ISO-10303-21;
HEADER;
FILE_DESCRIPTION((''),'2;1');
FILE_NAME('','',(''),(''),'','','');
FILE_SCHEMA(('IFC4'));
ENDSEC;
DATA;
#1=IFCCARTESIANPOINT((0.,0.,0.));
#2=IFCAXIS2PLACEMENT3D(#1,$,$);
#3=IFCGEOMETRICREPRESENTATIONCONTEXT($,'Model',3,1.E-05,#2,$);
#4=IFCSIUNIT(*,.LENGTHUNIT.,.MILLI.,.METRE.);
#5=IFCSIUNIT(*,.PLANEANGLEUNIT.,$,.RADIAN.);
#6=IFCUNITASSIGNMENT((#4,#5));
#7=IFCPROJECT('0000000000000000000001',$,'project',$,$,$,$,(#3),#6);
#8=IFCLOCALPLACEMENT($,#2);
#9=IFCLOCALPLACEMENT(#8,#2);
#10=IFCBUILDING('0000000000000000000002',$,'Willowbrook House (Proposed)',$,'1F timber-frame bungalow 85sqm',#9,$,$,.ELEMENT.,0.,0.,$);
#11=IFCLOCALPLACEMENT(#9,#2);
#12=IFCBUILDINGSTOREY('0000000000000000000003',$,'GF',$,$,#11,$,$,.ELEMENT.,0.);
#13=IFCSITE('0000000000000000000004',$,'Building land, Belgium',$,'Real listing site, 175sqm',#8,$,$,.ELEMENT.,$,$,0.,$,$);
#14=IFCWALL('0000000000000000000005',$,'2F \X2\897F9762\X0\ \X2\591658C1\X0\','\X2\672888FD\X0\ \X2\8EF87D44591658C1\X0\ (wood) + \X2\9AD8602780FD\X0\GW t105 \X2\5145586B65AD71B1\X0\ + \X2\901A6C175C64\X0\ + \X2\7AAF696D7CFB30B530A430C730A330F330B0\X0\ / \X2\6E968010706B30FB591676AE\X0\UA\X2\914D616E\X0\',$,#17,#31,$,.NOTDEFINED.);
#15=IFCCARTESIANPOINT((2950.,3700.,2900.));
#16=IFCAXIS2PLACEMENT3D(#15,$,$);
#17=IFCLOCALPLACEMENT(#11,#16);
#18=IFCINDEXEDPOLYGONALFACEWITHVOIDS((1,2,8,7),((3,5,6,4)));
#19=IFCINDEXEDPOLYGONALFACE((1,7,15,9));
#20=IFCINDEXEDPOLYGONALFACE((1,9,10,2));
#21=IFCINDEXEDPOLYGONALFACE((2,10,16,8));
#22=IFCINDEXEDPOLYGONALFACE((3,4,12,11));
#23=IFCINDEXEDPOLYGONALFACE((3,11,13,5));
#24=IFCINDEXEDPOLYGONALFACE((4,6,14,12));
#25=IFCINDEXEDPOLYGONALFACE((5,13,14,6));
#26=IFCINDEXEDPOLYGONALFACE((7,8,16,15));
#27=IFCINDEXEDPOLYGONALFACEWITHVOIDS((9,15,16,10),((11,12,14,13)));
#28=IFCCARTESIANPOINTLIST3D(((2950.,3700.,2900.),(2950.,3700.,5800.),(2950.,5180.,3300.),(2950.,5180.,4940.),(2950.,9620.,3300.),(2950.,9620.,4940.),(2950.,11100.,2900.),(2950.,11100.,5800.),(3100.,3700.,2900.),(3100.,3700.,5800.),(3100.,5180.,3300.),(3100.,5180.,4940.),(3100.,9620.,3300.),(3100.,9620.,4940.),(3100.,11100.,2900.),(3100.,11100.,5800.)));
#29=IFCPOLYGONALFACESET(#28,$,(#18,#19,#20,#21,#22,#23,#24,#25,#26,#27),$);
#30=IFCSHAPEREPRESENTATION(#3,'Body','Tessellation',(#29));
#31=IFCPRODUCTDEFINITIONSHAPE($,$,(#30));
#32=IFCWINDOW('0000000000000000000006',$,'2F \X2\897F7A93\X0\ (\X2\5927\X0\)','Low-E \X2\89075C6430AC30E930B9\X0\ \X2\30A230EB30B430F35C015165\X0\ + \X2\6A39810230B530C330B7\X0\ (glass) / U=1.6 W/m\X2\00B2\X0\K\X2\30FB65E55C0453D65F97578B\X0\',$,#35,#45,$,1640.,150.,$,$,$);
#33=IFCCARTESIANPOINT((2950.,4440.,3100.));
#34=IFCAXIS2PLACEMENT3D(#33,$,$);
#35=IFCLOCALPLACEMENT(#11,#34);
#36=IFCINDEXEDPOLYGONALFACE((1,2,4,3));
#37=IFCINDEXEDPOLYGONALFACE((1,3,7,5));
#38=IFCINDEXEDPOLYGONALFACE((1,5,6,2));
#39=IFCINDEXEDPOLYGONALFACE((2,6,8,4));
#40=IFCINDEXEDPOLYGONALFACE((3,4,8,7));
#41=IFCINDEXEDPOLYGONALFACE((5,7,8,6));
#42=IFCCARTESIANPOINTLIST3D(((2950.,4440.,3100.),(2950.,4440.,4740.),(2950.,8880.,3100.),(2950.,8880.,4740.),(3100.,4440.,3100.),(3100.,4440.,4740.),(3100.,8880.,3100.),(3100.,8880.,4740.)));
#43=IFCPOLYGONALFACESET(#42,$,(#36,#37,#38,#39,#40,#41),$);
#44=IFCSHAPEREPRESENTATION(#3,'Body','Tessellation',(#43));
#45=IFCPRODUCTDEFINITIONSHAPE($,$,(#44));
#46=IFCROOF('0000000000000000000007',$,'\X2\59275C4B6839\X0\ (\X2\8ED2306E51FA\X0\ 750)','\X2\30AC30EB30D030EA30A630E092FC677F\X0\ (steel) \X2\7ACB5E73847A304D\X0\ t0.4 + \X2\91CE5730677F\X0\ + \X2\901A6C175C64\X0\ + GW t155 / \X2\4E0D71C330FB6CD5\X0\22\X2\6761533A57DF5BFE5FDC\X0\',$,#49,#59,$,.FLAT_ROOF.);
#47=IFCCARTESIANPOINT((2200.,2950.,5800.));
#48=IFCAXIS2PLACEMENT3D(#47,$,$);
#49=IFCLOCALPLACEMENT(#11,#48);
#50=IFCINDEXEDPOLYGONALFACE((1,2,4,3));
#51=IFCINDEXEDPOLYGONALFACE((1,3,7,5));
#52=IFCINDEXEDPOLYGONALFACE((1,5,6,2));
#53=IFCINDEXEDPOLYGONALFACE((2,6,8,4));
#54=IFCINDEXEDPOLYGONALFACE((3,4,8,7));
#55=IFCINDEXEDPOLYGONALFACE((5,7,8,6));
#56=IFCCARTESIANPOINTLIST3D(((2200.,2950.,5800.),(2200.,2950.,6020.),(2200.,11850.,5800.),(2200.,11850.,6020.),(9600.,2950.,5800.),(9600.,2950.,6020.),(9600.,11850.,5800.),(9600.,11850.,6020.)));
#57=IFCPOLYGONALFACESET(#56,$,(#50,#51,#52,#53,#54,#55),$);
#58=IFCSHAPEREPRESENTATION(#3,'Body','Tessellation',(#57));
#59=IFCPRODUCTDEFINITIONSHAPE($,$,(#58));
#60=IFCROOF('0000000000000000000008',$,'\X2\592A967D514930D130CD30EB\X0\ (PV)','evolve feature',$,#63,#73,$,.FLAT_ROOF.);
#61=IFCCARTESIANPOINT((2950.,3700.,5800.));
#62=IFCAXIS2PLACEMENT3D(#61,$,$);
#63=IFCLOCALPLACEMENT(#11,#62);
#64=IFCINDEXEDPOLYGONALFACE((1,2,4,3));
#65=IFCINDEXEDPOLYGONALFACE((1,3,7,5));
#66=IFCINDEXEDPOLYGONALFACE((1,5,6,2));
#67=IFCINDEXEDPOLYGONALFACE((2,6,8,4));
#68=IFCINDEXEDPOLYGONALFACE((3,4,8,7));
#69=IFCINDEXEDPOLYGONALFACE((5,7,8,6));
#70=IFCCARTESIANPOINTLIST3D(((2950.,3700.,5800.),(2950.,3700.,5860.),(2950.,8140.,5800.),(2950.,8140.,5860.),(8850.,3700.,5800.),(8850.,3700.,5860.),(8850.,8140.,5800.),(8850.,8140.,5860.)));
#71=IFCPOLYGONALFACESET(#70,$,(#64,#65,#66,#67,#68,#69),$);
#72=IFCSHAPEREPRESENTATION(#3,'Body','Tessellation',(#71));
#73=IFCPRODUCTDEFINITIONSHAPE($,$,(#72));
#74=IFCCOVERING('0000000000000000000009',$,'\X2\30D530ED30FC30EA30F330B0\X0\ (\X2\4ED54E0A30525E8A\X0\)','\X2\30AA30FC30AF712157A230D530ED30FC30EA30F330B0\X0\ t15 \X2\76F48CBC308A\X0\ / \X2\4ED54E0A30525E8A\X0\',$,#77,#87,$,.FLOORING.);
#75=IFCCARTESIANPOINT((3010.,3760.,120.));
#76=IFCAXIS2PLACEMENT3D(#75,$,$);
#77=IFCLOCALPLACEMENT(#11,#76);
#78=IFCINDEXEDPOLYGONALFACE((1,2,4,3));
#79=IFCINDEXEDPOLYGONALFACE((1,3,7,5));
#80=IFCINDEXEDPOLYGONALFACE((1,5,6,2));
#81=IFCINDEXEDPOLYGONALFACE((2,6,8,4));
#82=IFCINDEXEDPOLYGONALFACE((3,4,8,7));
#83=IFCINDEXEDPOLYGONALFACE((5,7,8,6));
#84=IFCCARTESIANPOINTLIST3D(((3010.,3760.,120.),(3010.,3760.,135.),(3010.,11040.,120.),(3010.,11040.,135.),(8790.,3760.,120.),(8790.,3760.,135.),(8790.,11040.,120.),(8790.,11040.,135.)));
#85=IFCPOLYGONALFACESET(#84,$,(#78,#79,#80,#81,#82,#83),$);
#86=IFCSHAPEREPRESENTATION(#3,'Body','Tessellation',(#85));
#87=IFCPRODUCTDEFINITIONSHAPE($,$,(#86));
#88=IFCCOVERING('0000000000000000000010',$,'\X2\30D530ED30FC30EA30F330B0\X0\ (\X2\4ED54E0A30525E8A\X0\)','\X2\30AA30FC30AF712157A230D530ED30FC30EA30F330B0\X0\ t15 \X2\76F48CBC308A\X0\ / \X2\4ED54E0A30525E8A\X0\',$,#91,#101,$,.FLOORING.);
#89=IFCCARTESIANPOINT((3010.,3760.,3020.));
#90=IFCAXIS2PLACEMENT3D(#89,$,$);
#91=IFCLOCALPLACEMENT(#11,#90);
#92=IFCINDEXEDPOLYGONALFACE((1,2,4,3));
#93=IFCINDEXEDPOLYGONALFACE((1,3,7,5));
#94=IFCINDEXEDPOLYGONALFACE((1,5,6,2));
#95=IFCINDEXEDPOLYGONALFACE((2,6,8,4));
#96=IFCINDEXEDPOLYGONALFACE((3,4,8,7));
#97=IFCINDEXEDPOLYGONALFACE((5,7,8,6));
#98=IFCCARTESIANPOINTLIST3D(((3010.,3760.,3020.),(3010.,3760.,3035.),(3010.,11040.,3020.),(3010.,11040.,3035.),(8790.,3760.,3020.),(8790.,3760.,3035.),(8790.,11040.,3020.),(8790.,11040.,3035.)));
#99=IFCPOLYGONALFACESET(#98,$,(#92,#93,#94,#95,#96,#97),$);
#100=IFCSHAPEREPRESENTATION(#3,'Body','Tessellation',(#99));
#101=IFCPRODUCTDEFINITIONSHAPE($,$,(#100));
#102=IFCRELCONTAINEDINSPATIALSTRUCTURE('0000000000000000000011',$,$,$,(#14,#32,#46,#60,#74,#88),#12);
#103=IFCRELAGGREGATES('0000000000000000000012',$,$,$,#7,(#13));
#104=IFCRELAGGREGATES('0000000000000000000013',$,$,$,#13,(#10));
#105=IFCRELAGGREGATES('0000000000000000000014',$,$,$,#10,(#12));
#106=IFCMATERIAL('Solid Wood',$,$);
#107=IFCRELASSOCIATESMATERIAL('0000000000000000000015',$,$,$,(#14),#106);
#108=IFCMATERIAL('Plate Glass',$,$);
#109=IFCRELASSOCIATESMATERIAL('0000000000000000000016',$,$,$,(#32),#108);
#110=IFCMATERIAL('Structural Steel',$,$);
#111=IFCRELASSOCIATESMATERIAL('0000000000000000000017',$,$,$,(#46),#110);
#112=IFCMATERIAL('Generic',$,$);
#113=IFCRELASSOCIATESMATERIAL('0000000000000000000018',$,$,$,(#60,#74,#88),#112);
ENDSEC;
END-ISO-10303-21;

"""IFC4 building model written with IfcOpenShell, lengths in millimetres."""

from ifc_helpers import new_model, si_unit, frame, frame_2d, origin, place, context, project, spatial, rectangle, extrude, material, element, fill, save


model = new_model("IFC4")

# Units and contexts
model_context = context("Model", 3, precision=1e-05, world=origin())
ifc_project = project(units=[si_unit("LENGTHUNIT", "METRE", prefix="MILLI"), si_unit("PLANEANGLEUNIT", "RADIAN")], contexts=[model_context])

# Site, building, storey
site_placement = place(None, origin())
site = spatial("IfcSite", under=ifc_project, at=site_placement, Name="Building land, Belgium", ObjectType="Real listing site, 175sqm", CompositionType="ELEMENT", RefElevation=0.0)
building_placement = place(site_placement, origin())
building = spatial("IfcBuilding", under=site, at=building_placement, Name="Willowbrook House (Proposed)", ObjectType="1F timber-frame bungalow 85sqm", CompositionType="ELEMENT", ElevationOfRefHeight=0.0, ElevationOfTerrain=0.0)
storey_placement = place(building_placement, origin())
storey = spatial("IfcBuildingStorey", under=building, at=storey_placement, Name="GF", CompositionType="ELEMENT", Elevation=0.0)

# Shared definitions
ifc_material_1 = material(Name="Solid Wood")
ifc_material_2 = material(Name="Generic")

# Shared definitions
ifc_material_3 = material(Name="Plate Glass")

# Wall, opening, window
wall_1_placement = place(storey_placement, frame((2950.0, 3700.0, 2900.0)))
wall_1 = element("IfcWall", 1, at=wall_1_placement, inside=storey, material=ifc_material_1, Name="2F 西面 外壁", Description="木製 軸組外壁 (wood) + 高性能GW t105 充填断熱 + 通気層 + 窯業系サイディング / 準耐火・外皮UA配慮", PredefinedType="NOTDEFINED", context=model_context, shape_type="SweptSolid", body=[
    extrude(rectangle(XDim=150.0, YDim=7400.0, at=frame_2d((75.0, 3700.0))), frame((2950.0, 3700.0, 2900.0)), (0.0, 0.0, 1.0), 2900.0),
])
opening_1_placement = place(storey_placement, frame((2950.0, 4440.0, 3100.0)))
opening_1 = element("IfcOpeningElement", 2, at=opening_1_placement, cuts=wall_1, PredefinedType="NOTDEFINED", context=model_context, shape_type="SweptSolid", body=[
    extrude(rectangle(XDim=150.0, YDim=4440.0, at=frame_2d((75.0, 2220.0))), frame((2950.0, 4440.0, 3100.0)), (0.0, 0.0, 1.0), 1640.0),
])
window_1_placement = place(storey_placement, frame((2950.0, 4440.0, 3100.0)))
window_1 = element("IfcWindow", 3, at=window_1_placement, inside=storey, material=ifc_material_3, Name="2F 西窓 (大)", Description="Low-E 複層ガラス アルゴン封入 + 樹脂サッシ (glass) / U=1.6 W/m²K・日射取得型", OverallHeight=1640.0, OverallWidth=150.0, context=model_context, shape_type="SweptSolid", body=[
    extrude(rectangle(XDim=150.0, YDim=4440.0, at=frame_2d((75.0, 2220.0))), frame((2950.0, 4440.0, 3100.0)), (0.0, 0.0, 1.0), 1640.0),
])
fill(opening_1, window_1)

# Roofs
ifc_material_4 = material(Name="Structural Steel")
roof_1_placement = place(storey_placement, frame((2200.0, 2950.0, 5800.0)))
element("IfcRoof", 4, at=roof_1_placement, inside=storey, material=ifc_material_4, Name="大屋根 (軒の出 750)", Description="ガルバリウム鋼板 (steel) 立平葺き t0.4 + 野地板 + 通気層 + GW t155 / 不燃・法22条区域対応", PredefinedType="FLAT_ROOF", context=model_context, shape_type="SweptSolid", body=[
    extrude(rectangle(XDim=7400.0, YDim=8900.0, at=frame_2d((3700.0, 4450.0))), frame((2200.0, 2950.0, 5800.0)), (0.0, 0.0, 1.0), 220.0),
])
roof_2_placement = place(storey_placement, frame((2950.0, 3700.0, 5800.0)))
element("IfcRoof", 5, at=roof_2_placement, inside=storey, material=ifc_material_2, Name="太陽光パネル (PV)", Description="evolve feature", PredefinedType="FLAT_ROOF", context=model_context, shape_type="SweptSolid", body=[
    extrude(rectangle(XDim=5900.0, YDim=4440.0, at=frame_2d((2950.0, 2220.0))), frame((2950.0, 3700.0, 5800.0)), (0.0, 0.0, 1.0), 60.0),
])

# Coverings
covering_1_placement = place(storey_placement, frame((3010.0, 3760.0, 120.0)))
element("IfcCovering", 6, at=covering_1_placement, inside=storey, material=ifc_material_2, Name="フローリング (仕上げ床)", Description="オーク無垢フローリング t15 直貼り / 仕上げ床", PredefinedType="FLOORING", context=model_context, shape_type="SweptSolid", body=[
    extrude(rectangle(XDim=5780.0, YDim=7280.0, at=frame_2d((2890.0, 3640.0))), frame((3010.0, 3760.0, 120.0)), (0.0, 0.0, 1.0), 15.0),
])
covering_2_placement = place(storey_placement, frame((3010.0, 3760.0, 3020.0)))
element("IfcCovering", 7, at=covering_2_placement, inside=storey, material=ifc_material_2, Name="フローリング (仕上げ床)", Description="オーク無垢フローリング t15 直貼り / 仕上げ床", PredefinedType="FLOORING", context=model_context, shape_type="SweptSolid", body=[
    extrude(rectangle(XDim=5780.0, YDim=7280.0, at=frame_2d((2890.0, 3640.0))), frame((3010.0, 3760.0, 3020.0)), (0.0, 0.0, 1.0), 15.0),
])

save(model, "model.ifc")
